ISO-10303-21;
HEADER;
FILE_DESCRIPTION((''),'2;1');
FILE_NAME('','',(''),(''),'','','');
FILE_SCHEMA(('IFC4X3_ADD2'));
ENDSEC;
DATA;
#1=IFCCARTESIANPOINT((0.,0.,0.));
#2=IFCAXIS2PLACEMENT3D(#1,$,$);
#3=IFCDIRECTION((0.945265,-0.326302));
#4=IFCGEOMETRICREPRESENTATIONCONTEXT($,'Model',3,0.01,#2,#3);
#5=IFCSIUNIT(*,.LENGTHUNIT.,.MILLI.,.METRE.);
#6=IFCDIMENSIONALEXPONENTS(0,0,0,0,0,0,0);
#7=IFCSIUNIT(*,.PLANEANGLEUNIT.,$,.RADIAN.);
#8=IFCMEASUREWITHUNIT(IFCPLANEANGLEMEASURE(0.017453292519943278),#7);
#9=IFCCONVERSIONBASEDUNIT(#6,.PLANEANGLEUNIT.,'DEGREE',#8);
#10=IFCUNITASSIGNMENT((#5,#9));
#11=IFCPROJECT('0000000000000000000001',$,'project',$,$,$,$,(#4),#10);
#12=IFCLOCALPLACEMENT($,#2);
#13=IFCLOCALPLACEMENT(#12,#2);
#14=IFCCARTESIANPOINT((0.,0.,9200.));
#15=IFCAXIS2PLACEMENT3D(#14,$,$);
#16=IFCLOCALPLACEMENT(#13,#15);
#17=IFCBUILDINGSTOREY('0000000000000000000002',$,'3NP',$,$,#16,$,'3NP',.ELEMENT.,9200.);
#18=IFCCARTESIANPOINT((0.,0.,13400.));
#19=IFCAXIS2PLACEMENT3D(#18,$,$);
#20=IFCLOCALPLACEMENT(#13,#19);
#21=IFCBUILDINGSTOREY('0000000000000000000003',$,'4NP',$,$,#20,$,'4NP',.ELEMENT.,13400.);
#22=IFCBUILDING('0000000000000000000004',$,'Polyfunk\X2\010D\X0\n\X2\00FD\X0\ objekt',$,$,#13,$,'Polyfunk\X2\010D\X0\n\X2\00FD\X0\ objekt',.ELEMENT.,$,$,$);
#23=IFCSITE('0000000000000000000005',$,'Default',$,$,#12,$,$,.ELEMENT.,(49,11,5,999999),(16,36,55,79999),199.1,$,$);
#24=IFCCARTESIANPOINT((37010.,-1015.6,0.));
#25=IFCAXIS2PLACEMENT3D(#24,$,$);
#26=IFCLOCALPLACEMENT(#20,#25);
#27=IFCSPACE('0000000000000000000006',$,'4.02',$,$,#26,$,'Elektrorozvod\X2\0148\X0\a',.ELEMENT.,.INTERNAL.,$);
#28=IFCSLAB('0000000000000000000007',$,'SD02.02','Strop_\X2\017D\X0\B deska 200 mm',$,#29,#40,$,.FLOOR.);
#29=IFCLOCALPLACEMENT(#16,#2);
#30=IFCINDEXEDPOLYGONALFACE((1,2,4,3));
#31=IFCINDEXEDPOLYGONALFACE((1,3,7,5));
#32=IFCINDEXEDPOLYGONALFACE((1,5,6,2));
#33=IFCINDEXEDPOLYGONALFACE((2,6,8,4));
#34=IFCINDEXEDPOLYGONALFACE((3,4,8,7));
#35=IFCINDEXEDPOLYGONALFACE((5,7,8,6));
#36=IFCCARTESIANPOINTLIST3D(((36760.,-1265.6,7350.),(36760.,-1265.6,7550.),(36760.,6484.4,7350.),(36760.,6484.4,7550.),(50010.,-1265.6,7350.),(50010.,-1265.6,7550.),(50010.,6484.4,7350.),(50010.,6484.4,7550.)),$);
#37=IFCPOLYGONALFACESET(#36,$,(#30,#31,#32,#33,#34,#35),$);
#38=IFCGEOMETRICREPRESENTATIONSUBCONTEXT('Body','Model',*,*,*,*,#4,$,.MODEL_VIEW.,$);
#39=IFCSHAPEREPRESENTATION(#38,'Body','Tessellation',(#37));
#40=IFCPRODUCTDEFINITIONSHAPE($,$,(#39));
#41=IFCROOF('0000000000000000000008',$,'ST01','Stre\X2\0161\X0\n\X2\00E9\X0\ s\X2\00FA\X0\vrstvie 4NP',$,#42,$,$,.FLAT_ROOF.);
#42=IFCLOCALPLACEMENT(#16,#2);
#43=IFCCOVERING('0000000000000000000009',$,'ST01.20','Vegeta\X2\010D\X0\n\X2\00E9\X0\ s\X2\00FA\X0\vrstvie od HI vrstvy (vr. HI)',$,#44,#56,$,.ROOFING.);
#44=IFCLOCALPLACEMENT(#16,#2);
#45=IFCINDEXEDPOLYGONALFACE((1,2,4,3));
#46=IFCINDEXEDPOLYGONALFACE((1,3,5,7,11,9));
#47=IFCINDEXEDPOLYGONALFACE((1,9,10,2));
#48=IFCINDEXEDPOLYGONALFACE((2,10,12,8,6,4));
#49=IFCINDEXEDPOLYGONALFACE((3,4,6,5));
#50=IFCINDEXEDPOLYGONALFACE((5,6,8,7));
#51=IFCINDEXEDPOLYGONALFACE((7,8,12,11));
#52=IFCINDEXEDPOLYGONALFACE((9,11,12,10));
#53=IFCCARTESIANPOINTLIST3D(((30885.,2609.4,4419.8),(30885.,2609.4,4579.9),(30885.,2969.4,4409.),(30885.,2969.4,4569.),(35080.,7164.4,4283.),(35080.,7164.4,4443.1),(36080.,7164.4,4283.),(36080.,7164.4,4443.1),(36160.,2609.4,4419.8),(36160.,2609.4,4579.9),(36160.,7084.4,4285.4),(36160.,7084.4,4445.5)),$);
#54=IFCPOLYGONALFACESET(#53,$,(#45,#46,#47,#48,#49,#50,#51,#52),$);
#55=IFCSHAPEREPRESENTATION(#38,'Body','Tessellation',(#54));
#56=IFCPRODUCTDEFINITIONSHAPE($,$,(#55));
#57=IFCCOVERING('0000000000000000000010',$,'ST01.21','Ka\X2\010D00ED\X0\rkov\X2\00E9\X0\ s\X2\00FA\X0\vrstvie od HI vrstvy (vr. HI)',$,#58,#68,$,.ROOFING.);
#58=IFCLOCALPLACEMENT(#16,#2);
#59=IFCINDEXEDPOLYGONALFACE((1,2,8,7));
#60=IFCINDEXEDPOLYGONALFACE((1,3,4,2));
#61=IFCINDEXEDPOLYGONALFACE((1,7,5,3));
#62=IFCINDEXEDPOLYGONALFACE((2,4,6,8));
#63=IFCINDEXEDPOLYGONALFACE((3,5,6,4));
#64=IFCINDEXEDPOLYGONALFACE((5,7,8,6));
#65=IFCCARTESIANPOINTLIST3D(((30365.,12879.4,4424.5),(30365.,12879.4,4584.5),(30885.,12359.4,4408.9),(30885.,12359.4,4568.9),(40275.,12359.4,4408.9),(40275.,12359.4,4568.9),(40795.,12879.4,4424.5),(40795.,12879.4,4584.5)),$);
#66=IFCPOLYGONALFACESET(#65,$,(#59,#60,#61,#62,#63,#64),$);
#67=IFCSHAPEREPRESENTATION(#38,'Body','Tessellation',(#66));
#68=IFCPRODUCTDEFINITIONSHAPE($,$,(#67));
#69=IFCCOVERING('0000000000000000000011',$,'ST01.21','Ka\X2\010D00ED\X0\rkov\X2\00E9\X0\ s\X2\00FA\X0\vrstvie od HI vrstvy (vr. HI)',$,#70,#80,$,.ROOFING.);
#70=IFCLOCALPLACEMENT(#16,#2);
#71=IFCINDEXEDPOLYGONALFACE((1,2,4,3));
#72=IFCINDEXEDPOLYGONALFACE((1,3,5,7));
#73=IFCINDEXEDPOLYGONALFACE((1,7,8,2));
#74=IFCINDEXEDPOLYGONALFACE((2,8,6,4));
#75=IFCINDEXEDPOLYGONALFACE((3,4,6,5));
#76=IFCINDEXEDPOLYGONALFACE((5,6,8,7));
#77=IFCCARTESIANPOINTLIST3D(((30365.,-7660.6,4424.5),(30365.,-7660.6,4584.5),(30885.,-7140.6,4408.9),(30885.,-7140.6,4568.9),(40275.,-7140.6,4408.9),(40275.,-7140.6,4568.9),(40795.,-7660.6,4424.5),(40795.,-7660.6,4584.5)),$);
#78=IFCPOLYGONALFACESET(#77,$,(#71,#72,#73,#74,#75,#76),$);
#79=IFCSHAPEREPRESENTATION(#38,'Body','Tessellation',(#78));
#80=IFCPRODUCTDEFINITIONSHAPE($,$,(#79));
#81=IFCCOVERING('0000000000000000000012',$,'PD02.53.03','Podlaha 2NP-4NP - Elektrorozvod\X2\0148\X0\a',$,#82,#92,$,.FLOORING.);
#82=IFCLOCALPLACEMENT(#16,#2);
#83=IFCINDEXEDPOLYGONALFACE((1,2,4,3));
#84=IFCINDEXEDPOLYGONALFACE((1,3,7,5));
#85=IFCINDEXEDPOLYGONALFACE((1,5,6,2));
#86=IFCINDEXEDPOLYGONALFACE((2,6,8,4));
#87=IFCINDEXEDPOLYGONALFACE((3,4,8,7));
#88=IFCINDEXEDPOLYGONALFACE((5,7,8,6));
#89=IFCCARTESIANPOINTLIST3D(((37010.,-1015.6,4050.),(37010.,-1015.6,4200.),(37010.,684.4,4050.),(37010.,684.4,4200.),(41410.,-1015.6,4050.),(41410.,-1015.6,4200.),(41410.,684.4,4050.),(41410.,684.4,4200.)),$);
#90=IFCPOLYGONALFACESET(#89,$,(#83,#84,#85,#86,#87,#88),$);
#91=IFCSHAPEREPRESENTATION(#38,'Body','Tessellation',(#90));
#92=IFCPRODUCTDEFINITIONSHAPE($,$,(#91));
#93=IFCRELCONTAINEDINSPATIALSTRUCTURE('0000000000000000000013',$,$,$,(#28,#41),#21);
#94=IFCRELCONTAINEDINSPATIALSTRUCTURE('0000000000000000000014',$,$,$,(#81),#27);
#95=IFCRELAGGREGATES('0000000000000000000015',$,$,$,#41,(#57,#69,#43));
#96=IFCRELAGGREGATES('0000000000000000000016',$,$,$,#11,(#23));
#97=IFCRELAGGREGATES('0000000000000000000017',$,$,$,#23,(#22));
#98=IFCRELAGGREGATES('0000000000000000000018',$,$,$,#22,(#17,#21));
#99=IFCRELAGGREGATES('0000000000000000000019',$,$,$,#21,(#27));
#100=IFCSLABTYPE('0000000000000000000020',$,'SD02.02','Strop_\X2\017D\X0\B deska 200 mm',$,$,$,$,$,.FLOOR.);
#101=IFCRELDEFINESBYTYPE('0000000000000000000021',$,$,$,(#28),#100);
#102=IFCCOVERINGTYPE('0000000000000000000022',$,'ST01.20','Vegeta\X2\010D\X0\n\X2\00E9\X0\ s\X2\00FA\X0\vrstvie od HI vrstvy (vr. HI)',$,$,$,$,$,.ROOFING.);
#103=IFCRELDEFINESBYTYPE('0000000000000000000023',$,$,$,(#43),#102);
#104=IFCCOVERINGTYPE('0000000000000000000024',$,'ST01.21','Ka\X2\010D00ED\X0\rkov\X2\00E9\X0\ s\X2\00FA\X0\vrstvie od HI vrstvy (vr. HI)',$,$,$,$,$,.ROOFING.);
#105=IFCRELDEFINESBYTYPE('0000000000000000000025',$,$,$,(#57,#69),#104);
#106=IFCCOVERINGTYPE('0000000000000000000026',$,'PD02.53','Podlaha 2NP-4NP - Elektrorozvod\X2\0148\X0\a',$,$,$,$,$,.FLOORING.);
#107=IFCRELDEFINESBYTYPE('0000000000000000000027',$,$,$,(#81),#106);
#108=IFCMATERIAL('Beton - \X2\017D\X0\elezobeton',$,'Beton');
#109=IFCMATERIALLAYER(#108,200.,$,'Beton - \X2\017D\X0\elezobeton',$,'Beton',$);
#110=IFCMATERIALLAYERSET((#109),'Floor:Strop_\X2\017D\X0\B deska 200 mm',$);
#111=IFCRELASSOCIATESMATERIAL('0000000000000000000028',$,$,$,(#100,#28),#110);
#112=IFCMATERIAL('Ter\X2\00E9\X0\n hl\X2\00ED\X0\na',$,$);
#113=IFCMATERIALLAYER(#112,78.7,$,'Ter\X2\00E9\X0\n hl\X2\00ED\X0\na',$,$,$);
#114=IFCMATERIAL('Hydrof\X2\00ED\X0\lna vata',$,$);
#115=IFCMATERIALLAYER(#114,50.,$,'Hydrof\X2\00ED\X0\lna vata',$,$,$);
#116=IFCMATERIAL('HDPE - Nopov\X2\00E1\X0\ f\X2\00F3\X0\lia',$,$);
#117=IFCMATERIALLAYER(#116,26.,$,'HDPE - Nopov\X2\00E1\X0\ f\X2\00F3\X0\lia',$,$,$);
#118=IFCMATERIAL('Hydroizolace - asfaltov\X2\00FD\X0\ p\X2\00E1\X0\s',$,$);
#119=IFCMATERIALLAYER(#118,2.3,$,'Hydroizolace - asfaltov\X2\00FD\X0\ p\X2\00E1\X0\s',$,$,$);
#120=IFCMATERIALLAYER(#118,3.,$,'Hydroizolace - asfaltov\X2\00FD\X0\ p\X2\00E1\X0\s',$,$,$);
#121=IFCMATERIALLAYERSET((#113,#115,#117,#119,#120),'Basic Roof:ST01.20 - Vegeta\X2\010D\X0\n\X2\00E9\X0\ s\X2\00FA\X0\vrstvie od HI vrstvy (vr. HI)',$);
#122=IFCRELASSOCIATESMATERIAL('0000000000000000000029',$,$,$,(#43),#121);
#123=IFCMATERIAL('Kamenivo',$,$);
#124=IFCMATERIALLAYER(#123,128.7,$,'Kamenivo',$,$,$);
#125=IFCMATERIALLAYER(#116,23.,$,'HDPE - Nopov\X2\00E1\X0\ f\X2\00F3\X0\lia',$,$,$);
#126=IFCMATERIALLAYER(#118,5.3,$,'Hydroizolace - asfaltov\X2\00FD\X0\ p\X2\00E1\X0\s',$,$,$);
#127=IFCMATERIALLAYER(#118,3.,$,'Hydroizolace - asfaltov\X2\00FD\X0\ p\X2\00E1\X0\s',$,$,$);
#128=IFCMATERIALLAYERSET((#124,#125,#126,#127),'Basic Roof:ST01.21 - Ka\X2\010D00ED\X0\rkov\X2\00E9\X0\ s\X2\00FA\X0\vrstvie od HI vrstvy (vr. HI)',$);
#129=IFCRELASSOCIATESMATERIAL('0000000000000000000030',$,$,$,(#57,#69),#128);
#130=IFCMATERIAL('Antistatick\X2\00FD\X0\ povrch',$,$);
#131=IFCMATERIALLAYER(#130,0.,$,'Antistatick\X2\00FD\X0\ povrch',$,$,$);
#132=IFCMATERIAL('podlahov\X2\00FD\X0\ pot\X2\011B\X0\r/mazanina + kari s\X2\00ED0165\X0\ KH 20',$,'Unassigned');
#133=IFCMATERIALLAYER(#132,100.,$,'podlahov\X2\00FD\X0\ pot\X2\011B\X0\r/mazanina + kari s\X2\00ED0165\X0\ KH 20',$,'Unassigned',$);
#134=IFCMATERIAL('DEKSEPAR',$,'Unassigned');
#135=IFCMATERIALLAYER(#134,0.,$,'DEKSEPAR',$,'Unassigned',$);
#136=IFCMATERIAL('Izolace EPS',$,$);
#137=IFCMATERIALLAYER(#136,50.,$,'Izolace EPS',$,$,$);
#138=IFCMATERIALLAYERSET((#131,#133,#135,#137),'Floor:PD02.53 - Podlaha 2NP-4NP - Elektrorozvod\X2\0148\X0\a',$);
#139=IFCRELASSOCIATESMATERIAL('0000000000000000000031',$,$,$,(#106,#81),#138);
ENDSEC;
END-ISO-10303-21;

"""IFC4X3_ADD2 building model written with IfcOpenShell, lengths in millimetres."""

from ifc_helpers import new_model, entity, si_unit, converted_unit, direction, frame, frame_2d, origin, place, context, subcontext, project, spatial, polyline, rectangle, outline, extrude, material, layer, layer_set, layer_usage, type_object, element, aggregate, save


model = new_model("IFC4X3_ADD2")

# Units and contexts
model_context = context("Model", 3, precision=0.01, world=origin(), true_north=direction((0.945265, -0.326302)))
body_context = subcontext(model_context, "Body", "Model", "MODEL_VIEW")
ifc_project = project(units=[si_unit("LENGTHUNIT", "METRE", prefix="MILLI"), converted_unit("PLANEANGLEUNIT", "DEGREE", entity("IfcPlaneAngleMeasure", 0.017453292519943278), si_unit("PLANEANGLEUNIT", "RADIAN"), dimensions=[0, 0, 0, 0, 0, 0, 0])], contexts=[model_context])

# Site, building, storey
site_placement = place(None, origin())
site = spatial("IfcSite", under=ifc_project, at=site_placement, Name="Default", CompositionType="ELEMENT", RefLatitude=(49, 11, 5, 999999), RefLongitude=(16, 36, 55, 79999), RefElevation=199.1)
building_placement = place(site_placement, origin())
building = spatial("IfcBuilding", under=site, at=building_placement, Name="Polyfunkčný objekt", LongName="Polyfunkčný objekt", CompositionType="ELEMENT")
storey_1_placement = place(building_placement, frame((0.0, 0.0, 9200.0)))
storey_1 = spatial("IfcBuildingStorey", under=building, at=storey_1_placement, Name="3NP", LongName="3NP", CompositionType="ELEMENT", Elevation=9200.0)

# Shared definitions
storey_2_placement = place(building_placement, frame((0.0, 0.0, 13400.0)))
storey_2 = spatial("IfcBuildingStorey", under=building, at=storey_2_placement, Name="4NP", LongName="4NP", CompositionType="ELEMENT", Elevation=13400.0)

# Slab
ifc_material_1 = material(Name="Beton - Železobeton", Category="Beton")
ifc_layer_1 = layer(ifc_material_1, 200.0, Name="Beton - Železobeton", Category="Beton")
ifc_layer_set_1 = layer_set([ifc_layer_1], Name="Floor:Strop_ŽB deska 200 mm")
ifc_layer_usage_1 = layer_usage(ifc_layer_set_1, "AXIS3", "POSITIVE", 0.0)
slab_type = type_object("IfcSlabType", Name="SD02.02", Description="Strop_ŽB deska 200 mm", PredefinedType="FLOOR", material=ifc_layer_set_1)
slab_placement = place(storey_2_placement, origin())
element("IfcSlab", 1, at=slab_placement, inside=storey_2, type_object=slab_type, material=ifc_layer_usage_1, Name="SD02.02", Description="Strop_ŽB deska 200 mm", PredefinedType="FLOOR", context=body_context, shape_type="SweptSolid", body=[
    extrude(rectangle(XDim=7750.0, YDim=13250.0, at=frame_2d((0.0, 0.0), x_axis=(1.0, 0.0))), frame((43385.0, 2609.4, 3350.0), z_axis=(0.0, 0.0, -1.0), x_axis=(0.0, 1.0, 0.0)), (0.0, 0.0, 1.0), 200.0),
])

# Roof, coverings
roof = element("IfcRoof", 2, inside=storey_2, Name="ST01", Description="Strešné súvrstvie 4NP", PredefinedType="FLAT_ROOF")
ifc_material_2 = material(Name="Terén hlína")
ifc_layer_2 = layer(ifc_material_2, 78.7, Name="Terén hlína")
ifc_material_3 = material(Name="Hydrofílna vata")
ifc_layer_3 = layer(ifc_material_3, 50.0, Name="Hydrofílna vata")
ifc_material_4 = material(Name="HDPE - Nopová fólia")
ifc_layer_4 = layer(ifc_material_4, 26.0, Name="HDPE - Nopová fólia")
ifc_material_5 = material(Name="Hydroizolace - asfaltový pás")
ifc_layer_5 = layer(ifc_material_5, 2.3, Name="Hydroizolace - asfaltový pás")
ifc_layer_6 = layer(ifc_material_5, 3.0, Name="Hydroizolace - asfaltový pás")
ifc_layer_set_2 = layer_set([ifc_layer_2, ifc_layer_3, ifc_layer_4, ifc_layer_5, ifc_layer_6], Name="Basic Roof:ST01.20 - Vegetačné súvrstvie od HI vrstvy (vr. HI)")
covering_type_1 = type_object("IfcCoveringType", Name="ST01.20", Description="Vegetačné súvrstvie od HI vrstvy (vr. HI)", PredefinedType="ROOFING")
placement_1 = place(storey_2_placement, frame((30885.0, 2609.4, 83.0)))
covering_1_placement = place(placement_1, origin())
covering_1 = element("IfcCovering", 3, at=covering_1_placement, type_object=covering_type_1, material=ifc_layer_set_2, Name="ST01.20", Description="Vegetačné súvrstvie od HI vrstvy (vr. HI)", PredefinedType="ROOFING", context=body_context, shape_type="SweptSolid", body=[
    extrude(outline(polyline([(1557.5, 2278.5), (-2637.5, -1918.4), (-2637.5, -2278.5), (2637.5, -2278.5), (2637.5, 2198.5), (2557.5, 2278.5), (1557.5, 2278.5)])), frame((2637.5, 2277.5, 68.4), z_axis=(0.0, 0.030015, 0.999549), x_axis=(1.0, 0.0, 0.0)), (0.0, -0.030015, 0.999549), 160.1),
])
ifc_material_6 = material(Name="Kamenivo")
ifc_layer_7 = layer(ifc_material_6, 128.7, Name="Kamenivo")
ifc_layer_8 = layer(ifc_material_4, 23.0, Name="HDPE - Nopová fólia")
ifc_layer_9 = layer(ifc_material_5, 5.3, Name="Hydroizolace - asfaltový pás")
ifc_layer_10 = layer(ifc_material_5, 3.0, Name="Hydroizolace - asfaltový pás")
ifc_layer_set_3 = layer_set([ifc_layer_7, ifc_layer_8, ifc_layer_9, ifc_layer_10], Name="Basic Roof:ST01.21 - Kačírkové súvrstvie od HI vrstvy (vr. HI)")
covering_type_2 = type_object("IfcCoveringType", Name="ST01.21", Description="Kačírkové súvrstvie od HI vrstvy (vr. HI)", PredefinedType="ROOFING")
placement_2 = place(storey_2_placement, frame((30365.0, 12359.4, 208.9)))
covering_2_placement = place(placement_2, origin())
covering_2 = element("IfcCovering", 4, at=covering_2_placement, type_object=covering_type_2, material=ifc_layer_set_3, Name="ST01.21", Description="Kačírkové súvrstvie od HI vrstvy (vr. HI)", PredefinedType="ROOFING", context=body_context, shape_type="SweptSolid", body=[
    extrude(outline(polyline([(4695.0, -260.1), (5215.0, 260.1), (-5215.0, 260.1), (-4695.0, -260.1), (4695.0, -260.1)])), frame((5215.0, 260.0, 7.8), z_axis=(0.0, -0.030015, 0.999549), x_axis=(1.0, 0.0, 0.0)), (0.0, 0.030015, 0.999549), 160.1),
])
placement_3 = place(storey_2_placement, frame((30365.0, -7660.6, 208.9)))
covering_3_placement = place(placement_3, origin())
covering_3 = element("IfcCovering", 5, at=covering_3_placement, type_object=covering_type_2, material=ifc_layer_set_3, Name="ST01.21", Description="Kačírkové súvrstvie od HI vrstvy (vr. HI)", PredefinedType="ROOFING", context=body_context, shape_type="SweptSolid", body=[
    extrude(outline(polyline([(-4695.0, 260.1), (-5215.0, -260.1), (5215.0, -260.1), (4695.0, 260.1), (-4695.0, 260.1)])), frame((5215.0, 260.0, 7.8), z_axis=(0.0, 0.030015, 0.999549), x_axis=(1.0, 0.0, 0.0)), (0.0, -0.030015, 0.999549), 160.1),
])
aggregate(roof, [covering_2, covering_3, covering_1])

# Shared definitions
ifc_material_7 = material(Name="podlahový potěr/mazanina + kari síť KH 20", Category="Unassigned")
ifc_material_8 = material(Name="DEKSEPAR", Category="Unassigned")
ifc_material_9 = material(Name="Izolace EPS")

# Shared definitions
space_1_placement = place(storey_2_placement, frame((37010.0, -1015.6, 0.0)))
space_1 = spatial("IfcSpace", under=storey_2, at=space_1_placement, Name="4.02", LongName="Elektrorozvodňa", CompositionType="ELEMENT", PredefinedType="INTERNAL")

# Covering
ifc_material_10 = material(Name="Antistatický povrch")
ifc_layer_11 = layer(ifc_material_10, 0.0, Name="Antistatický povrch")
ifc_layer_12 = layer(ifc_material_7, 100.0, Name="podlahový potěr/mazanina + kari síť KH 20", Category="Unassigned")
ifc_layer_13 = layer(ifc_material_8, 0.0, Name="DEKSEPAR", Category="Unassigned")
ifc_layer_14 = layer(ifc_material_9, 50.0, Name="Izolace EPS")
ifc_layer_set_4 = layer_set([ifc_layer_11, ifc_layer_12, ifc_layer_13, ifc_layer_14], Name="Floor:PD02.53 - Podlaha 2NP-4NP - Elektrorozvodňa")
ifc_layer_usage_2 = layer_usage(ifc_layer_set_4, "AXIS3", "POSITIVE", 0.0)
covering_type_3 = type_object("IfcCoveringType", Name="PD02.53", Description="Podlaha 2NP-4NP - Elektrorozvodňa", PredefinedType="FLOORING", material=ifc_layer_set_4)
covering_4_placement = place(storey_2_placement, origin())
element("IfcCovering", 6, at=covering_4_placement, inside=space_1, type_object=covering_type_3, material=ifc_layer_usage_2, Name="PD02.53.03", Description="Podlaha 2NP-4NP - Elektrorozvodňa", PredefinedType="FLOORING", context=body_context, shape_type="SweptSolid", body=[
    extrude(rectangle(XDim=1700.0, YDim=4400.0, at=frame_2d((0.0, 0.0), x_axis=(1.0, 0.0))), frame((39210.0, -165.6, 0.0), z_axis=(0.0, 0.0, -1.0), x_axis=(0.0, 1.0, 0.0)), (0.0, 0.0, 1.0), 150.0),
])

save(model, "model.ifc")
